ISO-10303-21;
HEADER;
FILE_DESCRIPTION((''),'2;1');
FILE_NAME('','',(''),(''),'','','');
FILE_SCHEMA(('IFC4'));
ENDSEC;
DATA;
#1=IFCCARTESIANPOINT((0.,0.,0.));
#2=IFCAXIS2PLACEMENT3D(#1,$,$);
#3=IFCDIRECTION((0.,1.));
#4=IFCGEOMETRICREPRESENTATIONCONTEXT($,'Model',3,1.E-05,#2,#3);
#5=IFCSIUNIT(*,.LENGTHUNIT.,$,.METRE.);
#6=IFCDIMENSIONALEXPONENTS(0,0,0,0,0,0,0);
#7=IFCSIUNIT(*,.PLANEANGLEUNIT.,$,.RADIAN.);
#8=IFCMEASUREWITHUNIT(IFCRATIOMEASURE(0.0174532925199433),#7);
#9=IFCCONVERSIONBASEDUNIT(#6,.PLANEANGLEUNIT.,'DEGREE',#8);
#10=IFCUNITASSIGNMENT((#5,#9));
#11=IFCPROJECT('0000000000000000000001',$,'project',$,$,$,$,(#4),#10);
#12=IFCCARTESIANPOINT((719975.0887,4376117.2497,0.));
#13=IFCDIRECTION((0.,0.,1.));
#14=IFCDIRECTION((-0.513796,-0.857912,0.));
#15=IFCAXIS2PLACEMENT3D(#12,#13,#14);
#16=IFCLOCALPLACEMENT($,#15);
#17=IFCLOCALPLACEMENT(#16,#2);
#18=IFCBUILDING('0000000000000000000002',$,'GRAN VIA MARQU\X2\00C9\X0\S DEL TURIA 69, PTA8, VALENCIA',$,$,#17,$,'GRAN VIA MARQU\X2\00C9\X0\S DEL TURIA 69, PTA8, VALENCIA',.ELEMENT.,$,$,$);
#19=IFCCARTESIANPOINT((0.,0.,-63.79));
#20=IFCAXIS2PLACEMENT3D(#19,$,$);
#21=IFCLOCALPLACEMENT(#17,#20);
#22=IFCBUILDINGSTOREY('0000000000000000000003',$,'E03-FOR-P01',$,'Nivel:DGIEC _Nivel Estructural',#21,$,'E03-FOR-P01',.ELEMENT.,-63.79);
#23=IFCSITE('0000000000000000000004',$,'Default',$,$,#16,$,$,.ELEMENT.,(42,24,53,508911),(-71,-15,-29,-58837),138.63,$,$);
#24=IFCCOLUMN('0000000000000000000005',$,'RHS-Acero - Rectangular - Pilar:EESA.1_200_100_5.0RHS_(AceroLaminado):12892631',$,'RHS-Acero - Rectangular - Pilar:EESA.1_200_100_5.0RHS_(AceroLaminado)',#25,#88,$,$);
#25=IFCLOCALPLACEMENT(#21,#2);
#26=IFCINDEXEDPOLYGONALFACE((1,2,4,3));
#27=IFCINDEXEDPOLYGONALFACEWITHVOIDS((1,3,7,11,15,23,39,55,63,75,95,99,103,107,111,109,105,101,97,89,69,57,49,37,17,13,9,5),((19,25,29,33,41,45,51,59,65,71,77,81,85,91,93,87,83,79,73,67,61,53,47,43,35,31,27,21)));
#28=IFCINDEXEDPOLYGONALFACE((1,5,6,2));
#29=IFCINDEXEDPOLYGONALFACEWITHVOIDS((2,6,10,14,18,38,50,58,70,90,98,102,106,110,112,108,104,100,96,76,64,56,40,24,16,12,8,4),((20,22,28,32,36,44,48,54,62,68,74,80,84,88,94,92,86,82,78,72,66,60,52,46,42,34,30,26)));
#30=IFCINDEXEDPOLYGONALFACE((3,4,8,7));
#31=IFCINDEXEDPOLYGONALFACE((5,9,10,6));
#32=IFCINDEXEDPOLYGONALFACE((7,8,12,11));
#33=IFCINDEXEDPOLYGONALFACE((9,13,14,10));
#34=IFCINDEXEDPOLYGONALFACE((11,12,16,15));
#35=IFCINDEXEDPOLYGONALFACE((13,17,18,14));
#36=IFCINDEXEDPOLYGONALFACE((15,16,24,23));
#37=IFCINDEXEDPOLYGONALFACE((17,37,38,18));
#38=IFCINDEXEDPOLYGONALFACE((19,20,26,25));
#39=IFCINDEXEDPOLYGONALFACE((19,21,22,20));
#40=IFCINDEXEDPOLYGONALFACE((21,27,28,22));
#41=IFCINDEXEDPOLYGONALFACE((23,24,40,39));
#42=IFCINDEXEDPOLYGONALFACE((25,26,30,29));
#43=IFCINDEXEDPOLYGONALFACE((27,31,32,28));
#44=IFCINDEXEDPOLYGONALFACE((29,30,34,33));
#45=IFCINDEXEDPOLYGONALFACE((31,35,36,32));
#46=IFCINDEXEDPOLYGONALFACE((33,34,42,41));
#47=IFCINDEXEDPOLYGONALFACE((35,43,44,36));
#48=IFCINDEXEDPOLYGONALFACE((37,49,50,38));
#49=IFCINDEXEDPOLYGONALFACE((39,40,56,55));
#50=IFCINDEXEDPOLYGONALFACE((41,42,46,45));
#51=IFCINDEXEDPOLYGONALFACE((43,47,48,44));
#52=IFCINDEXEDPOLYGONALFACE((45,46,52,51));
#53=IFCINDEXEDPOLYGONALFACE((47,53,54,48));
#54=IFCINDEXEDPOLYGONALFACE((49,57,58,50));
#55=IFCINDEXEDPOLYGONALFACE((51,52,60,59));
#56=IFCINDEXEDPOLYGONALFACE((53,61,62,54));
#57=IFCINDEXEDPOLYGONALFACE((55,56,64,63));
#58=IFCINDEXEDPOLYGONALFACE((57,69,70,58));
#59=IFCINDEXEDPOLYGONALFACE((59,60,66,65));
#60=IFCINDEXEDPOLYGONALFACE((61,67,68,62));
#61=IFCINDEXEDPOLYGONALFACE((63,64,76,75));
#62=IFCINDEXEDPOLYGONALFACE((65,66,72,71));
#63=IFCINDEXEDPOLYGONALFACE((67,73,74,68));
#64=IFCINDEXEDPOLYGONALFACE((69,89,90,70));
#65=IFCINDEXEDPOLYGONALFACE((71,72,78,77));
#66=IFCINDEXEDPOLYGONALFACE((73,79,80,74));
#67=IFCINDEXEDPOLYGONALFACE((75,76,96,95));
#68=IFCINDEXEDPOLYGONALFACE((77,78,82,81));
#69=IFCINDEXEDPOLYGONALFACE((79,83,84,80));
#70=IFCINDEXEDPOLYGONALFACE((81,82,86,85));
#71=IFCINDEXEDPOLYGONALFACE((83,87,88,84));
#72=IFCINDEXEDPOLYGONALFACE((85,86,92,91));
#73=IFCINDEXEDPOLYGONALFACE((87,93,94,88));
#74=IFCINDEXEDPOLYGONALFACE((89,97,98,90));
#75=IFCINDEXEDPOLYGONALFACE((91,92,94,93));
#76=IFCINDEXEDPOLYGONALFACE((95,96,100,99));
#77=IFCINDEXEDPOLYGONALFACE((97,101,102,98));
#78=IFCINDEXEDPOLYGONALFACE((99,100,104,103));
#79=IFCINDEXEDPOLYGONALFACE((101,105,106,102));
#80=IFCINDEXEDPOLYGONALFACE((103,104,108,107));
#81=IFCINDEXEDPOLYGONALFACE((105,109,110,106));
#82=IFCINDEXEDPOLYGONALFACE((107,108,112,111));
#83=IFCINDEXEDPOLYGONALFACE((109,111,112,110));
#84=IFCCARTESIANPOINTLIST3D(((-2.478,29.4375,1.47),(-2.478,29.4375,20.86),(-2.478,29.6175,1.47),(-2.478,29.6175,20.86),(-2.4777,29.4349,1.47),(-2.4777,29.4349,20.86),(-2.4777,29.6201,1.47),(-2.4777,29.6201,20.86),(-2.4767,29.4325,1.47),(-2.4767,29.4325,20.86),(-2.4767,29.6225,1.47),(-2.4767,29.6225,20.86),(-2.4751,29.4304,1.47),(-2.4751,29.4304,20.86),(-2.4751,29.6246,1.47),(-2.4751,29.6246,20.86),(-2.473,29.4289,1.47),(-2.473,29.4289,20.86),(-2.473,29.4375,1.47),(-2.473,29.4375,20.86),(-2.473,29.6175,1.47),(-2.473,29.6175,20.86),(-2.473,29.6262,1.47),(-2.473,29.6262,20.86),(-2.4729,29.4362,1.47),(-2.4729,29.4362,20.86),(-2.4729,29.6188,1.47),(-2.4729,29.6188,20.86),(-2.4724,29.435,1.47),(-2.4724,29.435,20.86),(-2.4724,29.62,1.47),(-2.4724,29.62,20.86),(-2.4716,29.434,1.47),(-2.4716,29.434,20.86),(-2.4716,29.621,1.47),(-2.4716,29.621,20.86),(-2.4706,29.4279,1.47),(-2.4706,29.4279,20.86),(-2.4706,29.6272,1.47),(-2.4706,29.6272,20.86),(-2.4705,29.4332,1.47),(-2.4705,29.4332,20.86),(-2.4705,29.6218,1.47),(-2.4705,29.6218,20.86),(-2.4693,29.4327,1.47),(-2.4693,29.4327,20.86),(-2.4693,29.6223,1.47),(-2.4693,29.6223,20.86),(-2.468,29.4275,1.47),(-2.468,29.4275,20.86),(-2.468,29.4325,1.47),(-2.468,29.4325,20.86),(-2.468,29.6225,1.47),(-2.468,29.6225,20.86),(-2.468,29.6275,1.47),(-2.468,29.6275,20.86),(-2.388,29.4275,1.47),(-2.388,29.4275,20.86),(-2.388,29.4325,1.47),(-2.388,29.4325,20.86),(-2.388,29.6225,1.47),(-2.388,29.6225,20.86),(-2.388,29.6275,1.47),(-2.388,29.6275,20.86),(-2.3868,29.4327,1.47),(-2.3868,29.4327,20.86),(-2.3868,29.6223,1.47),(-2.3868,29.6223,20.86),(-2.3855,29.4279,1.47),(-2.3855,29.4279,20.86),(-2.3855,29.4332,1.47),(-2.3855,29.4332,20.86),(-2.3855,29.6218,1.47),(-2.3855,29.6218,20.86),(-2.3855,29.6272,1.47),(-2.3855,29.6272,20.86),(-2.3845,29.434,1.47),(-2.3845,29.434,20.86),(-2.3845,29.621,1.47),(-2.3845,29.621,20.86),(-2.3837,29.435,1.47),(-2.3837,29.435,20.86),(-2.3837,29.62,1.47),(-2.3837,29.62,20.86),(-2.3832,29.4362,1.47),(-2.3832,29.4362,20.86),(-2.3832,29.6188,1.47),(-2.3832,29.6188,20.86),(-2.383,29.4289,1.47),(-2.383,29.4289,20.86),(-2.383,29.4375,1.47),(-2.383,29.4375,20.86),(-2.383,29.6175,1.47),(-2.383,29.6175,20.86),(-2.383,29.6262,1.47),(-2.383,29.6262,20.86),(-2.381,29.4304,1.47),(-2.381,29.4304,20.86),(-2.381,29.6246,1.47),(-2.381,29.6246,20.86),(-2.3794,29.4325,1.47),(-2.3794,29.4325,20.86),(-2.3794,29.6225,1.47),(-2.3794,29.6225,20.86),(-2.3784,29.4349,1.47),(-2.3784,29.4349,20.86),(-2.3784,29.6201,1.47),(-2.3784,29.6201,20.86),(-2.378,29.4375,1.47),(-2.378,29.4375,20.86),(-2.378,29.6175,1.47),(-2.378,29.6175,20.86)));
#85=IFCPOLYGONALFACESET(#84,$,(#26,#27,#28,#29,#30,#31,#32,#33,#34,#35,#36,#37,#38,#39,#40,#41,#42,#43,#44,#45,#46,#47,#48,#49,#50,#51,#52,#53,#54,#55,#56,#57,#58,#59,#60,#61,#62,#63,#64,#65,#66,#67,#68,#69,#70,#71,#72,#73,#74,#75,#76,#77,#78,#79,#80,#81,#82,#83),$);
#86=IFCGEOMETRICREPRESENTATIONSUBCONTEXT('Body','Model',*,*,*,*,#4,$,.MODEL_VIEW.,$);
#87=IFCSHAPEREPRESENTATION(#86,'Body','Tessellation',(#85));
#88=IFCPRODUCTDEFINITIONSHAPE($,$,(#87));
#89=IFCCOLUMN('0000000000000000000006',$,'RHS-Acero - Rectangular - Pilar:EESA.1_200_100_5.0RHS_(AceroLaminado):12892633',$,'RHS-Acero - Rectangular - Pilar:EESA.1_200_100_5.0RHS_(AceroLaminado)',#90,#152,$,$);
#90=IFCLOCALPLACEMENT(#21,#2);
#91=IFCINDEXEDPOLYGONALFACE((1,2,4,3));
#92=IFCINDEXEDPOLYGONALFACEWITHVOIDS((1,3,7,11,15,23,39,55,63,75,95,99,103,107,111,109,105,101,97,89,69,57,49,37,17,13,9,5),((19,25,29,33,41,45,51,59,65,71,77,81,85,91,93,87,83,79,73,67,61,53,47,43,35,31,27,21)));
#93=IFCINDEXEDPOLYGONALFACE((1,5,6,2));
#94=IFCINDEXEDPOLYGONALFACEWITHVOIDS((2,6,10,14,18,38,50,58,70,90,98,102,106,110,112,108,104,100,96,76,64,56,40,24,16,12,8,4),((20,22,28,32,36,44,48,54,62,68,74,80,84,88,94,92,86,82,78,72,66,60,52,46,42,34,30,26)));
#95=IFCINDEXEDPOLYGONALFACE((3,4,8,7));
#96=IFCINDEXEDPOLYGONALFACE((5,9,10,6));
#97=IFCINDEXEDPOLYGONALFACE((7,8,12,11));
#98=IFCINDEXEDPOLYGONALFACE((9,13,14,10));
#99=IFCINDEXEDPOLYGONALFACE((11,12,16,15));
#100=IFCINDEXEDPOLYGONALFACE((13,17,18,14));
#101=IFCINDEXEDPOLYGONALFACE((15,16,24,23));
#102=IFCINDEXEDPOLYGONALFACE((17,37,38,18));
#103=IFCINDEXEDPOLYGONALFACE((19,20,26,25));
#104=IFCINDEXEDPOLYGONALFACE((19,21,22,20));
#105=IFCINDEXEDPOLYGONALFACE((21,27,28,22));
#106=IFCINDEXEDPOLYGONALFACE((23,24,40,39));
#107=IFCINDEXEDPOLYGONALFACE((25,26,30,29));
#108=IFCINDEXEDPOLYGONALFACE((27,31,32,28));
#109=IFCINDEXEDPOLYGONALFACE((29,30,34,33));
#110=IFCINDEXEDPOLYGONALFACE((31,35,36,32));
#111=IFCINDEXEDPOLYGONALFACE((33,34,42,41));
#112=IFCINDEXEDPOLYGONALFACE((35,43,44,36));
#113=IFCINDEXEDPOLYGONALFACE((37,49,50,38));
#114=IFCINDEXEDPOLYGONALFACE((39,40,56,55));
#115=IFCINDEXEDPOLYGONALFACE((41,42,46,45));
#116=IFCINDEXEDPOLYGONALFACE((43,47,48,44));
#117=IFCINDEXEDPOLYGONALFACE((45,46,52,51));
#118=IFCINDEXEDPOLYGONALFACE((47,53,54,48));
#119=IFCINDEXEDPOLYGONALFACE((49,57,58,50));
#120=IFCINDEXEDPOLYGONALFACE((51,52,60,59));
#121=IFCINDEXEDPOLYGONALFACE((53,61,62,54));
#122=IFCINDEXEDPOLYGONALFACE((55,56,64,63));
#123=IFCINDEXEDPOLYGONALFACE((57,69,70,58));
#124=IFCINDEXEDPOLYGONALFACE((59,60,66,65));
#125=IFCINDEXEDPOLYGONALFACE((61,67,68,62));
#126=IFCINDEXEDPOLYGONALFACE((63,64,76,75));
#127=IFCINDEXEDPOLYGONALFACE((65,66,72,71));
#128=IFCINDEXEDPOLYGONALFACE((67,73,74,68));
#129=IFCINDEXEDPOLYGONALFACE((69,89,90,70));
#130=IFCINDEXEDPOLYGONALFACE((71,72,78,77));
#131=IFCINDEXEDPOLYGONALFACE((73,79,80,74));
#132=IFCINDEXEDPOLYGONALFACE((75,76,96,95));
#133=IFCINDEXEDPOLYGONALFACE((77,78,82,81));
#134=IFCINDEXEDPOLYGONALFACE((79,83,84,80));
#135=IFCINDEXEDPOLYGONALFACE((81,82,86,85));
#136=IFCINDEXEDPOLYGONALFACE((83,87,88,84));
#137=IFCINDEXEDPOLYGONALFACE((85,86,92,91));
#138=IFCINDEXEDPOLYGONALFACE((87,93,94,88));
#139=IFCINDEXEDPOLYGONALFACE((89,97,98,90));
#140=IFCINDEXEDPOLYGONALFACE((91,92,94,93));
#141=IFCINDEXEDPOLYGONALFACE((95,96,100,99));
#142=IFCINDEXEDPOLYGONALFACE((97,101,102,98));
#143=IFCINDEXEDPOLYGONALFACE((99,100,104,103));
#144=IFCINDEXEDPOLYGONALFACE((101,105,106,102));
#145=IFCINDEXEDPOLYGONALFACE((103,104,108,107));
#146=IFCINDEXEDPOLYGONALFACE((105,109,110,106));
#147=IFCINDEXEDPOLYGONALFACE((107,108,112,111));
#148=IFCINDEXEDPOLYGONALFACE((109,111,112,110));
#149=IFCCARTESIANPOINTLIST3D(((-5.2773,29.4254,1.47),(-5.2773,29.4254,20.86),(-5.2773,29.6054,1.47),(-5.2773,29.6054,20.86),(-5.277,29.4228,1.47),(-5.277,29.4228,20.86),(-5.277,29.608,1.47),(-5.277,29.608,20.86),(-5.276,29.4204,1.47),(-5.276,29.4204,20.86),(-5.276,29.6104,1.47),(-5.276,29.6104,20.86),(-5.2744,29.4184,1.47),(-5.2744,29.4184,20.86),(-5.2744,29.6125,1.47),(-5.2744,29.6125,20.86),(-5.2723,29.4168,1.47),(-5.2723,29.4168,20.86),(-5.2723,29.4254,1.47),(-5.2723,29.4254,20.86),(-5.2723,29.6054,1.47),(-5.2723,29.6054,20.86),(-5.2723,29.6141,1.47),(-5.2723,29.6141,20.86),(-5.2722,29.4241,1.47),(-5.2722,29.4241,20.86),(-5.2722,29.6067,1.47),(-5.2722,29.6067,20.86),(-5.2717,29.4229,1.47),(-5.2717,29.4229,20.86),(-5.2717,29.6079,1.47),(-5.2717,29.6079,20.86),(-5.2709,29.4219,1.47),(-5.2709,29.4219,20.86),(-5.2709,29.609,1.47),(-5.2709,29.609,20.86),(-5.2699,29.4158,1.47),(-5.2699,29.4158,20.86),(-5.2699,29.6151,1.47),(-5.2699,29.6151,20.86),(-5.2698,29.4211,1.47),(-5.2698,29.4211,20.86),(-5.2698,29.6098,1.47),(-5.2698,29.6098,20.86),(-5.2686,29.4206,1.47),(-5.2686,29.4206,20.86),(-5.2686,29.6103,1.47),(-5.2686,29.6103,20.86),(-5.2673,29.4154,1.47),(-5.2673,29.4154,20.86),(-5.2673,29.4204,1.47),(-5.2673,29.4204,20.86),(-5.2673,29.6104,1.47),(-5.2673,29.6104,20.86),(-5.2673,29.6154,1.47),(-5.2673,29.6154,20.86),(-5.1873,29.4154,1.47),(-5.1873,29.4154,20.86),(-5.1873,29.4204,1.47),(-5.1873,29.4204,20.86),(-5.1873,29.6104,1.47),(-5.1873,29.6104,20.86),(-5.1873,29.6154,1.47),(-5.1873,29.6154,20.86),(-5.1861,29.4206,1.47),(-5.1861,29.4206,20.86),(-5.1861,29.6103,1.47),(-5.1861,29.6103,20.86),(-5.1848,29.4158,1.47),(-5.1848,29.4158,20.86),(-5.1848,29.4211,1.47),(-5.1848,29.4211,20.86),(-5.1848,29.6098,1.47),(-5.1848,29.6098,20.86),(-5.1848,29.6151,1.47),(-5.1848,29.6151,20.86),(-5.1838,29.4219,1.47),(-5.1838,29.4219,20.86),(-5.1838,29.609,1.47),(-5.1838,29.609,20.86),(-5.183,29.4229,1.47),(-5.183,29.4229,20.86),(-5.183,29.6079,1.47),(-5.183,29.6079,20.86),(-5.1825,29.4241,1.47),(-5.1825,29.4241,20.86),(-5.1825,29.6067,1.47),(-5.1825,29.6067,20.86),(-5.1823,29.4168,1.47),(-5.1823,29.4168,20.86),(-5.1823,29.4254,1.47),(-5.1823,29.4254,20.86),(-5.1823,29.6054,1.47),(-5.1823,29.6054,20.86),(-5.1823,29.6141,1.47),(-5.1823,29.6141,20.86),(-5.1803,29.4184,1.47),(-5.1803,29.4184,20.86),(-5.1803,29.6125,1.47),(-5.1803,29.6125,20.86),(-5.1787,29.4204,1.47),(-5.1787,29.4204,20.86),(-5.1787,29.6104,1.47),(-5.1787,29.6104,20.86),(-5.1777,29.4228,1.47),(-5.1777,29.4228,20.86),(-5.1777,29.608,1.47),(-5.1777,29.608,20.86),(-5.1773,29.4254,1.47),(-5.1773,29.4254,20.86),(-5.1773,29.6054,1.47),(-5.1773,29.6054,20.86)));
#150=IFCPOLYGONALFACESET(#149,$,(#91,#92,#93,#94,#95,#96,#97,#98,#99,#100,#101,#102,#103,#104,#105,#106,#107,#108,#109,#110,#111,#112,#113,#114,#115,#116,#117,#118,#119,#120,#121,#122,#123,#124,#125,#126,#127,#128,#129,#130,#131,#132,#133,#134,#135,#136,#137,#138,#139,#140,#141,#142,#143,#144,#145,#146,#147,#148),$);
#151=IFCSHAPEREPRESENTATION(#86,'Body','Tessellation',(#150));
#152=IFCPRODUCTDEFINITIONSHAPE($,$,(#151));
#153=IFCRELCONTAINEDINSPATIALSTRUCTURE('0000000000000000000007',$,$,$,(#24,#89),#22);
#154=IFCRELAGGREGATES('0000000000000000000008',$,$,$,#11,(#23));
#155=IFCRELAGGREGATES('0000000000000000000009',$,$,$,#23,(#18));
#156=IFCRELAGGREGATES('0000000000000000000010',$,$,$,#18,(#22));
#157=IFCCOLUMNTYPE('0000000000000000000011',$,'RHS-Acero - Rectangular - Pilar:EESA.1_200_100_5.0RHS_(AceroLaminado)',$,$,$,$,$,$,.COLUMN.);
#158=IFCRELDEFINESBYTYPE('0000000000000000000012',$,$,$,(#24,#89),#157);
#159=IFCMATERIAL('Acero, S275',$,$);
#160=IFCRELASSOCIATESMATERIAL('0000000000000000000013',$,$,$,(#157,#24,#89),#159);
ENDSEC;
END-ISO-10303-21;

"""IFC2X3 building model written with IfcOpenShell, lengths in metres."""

from ifc_helpers import new_model, entity, si_unit, converted_unit, direction, frame, frame_2d, origin, place, context, subcontext, project, spatial, polyline, circle_curve, parameter, trimmed, segment, composite_curve, outline, extrude, source, transform, mapped, material, type_object, type_shapes, element, save


model = new_model("IFC2X3")

# Units and contexts
model_context = context("Model", 3, precision=1e-05, world=origin(), true_north=direction((0.0, 1.0)))
body_context = subcontext(model_context, "Body", "Model", "MODEL_VIEW")
ifc_project = project(units=[si_unit("LENGTHUNIT", "METRE"), converted_unit("PLANEANGLEUNIT", "DEGREE", entity("IfcRatioMeasure", 0.0174532925199433), si_unit("PLANEANGLEUNIT", "RADIAN"), dimensions=[0, 0, 0, 0, 0, 0, 0])], contexts=[model_context])

# Site, building, storey
site_placement = place(None, frame((719975.0887, 4376117.2497, 0.0), z_axis=(0.0, 0.0, 1.0), x_axis=(-0.513796, -0.857912, 0.0)))
site = spatial("IfcSite", under=ifc_project, at=site_placement, Name="Default", CompositionType="ELEMENT", RefLatitude=(42, 24, 53, 508911), RefLongitude=(-71, -15, -29, -58837), RefElevation=138.63)
building_placement = place(site_placement, origin())
building = spatial("IfcBuilding", under=site, at=building_placement, Name="GRAN VIA MARQUÉS DEL TURIA 69, PTA8, VALENCIA", LongName="GRAN VIA MARQUÉS DEL TURIA 69, PTA8, VALENCIA", CompositionType="ELEMENT")
storey_placement = place(building_placement, frame((0.0, 0.0, -63.79)))
storey = spatial("IfcBuildingStorey", under=building, at=storey_placement, Name="E03-FOR-P01", ObjectType="Nivel:DGIEC _Nivel Estructural", LongName="E03-FOR-P01", CompositionType="ELEMENT", Elevation=-63.79)

# Columns
ifc_material_1 = material(Name="Acero, S275")
column_type_1 = type_object("IfcColumnType", Name="RHS-Acero - Rectangular - Pilar:EESA.1_200_100_5.0RHS_(AceroLaminado)", PredefinedType="COLUMN", material=ifc_material_1)
shared_shape_1 = source(origin(), body_context, "Body", "SweptSolid", [
    extrude(outline(composite_curve([segment(polyline([(-0.04, -0.1), (0.04, -0.1)]), True, "CONTINUOUS"), segment(trimmed(circle_curve(frame_2d((0.04, -0.09), x_axis=(-1.0, 0.0)), 0.01), [parameter(90.0)], [parameter(180.0)], True, "PARAMETER"), True, "CONTINUOUS"), segment(polyline([(0.05, -0.09), (0.05, 0.09)]), True, "CONTINUOUS"), segment(trimmed(circle_curve(frame_2d((0.04, 0.09), x_axis=(-1.0, 0.0)), 0.01), [parameter(180.0)], [parameter(270.0)], True, "PARAMETER"), True, "CONTINUOUS"), segment(polyline([(0.04, 0.1), (-0.04, 0.1)]), True, "CONTINUOUS"), segment(trimmed(circle_curve(frame_2d((-0.04, 0.09), x_axis=(-1.0, 0.0)), 0.01), [parameter(270.0)], [parameter(360.0)], True, "PARAMETER"), True, "CONTINUOUS"), segment(polyline([(-0.05, 0.09), (-0.05, -0.09)]), True, "CONTINUOUS"), segment(trimmed(circle_curve(frame_2d((-0.04, -0.09), x_axis=(-1.0, 0.0)), 0.01), [parameter(360.0)], [parameter(90.0)], True, "PARAMETER"), True, "CONTINUOUS")], self_intersect=False), holes=[composite_curve([segment(trimmed(circle_curve(frame_2d((-0.04, -0.09), x_axis=(-1.0, 0.0)), 0.005), [parameter(0.0)], [parameter(90.0)], True, "PARAMETER"), False, "CONTINUOUS"), segment(polyline([(-0.045, -0.09), (-0.045, 0.09)]), True, "CONTINUOUS"), segment(trimmed(circle_curve(frame_2d((-0.04, 0.09), x_axis=(-1.0, 0.0)), 0.005), [parameter(270.0)], [parameter(0.0)], True, "PARAMETER"), False, "CONTINUOUS"), segment(polyline([(-0.04, 0.095), (0.04, 0.095)]), True, "CONTINUOUS"), segment(trimmed(circle_curve(frame_2d((0.04, 0.09), x_axis=(-1.0, 0.0)), 0.005), [parameter(180.0)], [parameter(270.0)], True, "PARAMETER"), False, "CONTINUOUS"), segment(polyline([(0.045, 0.09), (0.045, -0.09)]), True, "CONTINUOUS"), segment(trimmed(circle_curve(frame_2d((0.04, -0.09), x_axis=(-1.0, 0.0)), 0.005), [parameter(90.0)], [parameter(180.0)], True, "PARAMETER"), False, "CONTINUOUS"), segment(polyline([(0.04, -0.095), (-0.04, -0.095)]), True, "CONTINUOUS")], self_intersect=False)]), frame((0.0, 0.0, -62.32), z_axis=(0.0, 0.0, 1.0), x_axis=(-1.0, 0.0, 0.0)), (0.0, 0.0, 1.0), 19.39),
])
type_shapes(column_type_1, [shared_shape_1])
for number, where, z_axis, x_axis, name in (
    (1, (-2.428, 29.5275, 63.79), (0.0, 0.0, 1.0), (-1.0, 0.0, 0.0), "RHS-Acero - Rectangular - Pilar:EESA.1_200_100_5.0RHS_(AceroLaminado):12892631"),
    (2, (-5.2273, 29.5154, 63.79), (0.0, 0.0, 1.0), (-1.0, 0.0, 0.0), "RHS-Acero - Rectangular - Pilar:EESA.1_200_100_5.0RHS_(AceroLaminado):12892633"),
):
    element("IfcColumn", number, at=place(storey_placement, frame(where, z_axis=z_axis, x_axis=x_axis)), inside=storey, type_object=column_type_1, material=ifc_material_1, Name=name, ObjectType="RHS-Acero - Rectangular - Pilar:EESA.1_200_100_5.0RHS_(AceroLaminado)", context=body_context, shape_type="MappedRepresentation", body=[
        mapped(shared_shape_1, transform((0.0, 0.0, 0.0), scale=1.0)),
    ])

save(model, "model.ifc")
